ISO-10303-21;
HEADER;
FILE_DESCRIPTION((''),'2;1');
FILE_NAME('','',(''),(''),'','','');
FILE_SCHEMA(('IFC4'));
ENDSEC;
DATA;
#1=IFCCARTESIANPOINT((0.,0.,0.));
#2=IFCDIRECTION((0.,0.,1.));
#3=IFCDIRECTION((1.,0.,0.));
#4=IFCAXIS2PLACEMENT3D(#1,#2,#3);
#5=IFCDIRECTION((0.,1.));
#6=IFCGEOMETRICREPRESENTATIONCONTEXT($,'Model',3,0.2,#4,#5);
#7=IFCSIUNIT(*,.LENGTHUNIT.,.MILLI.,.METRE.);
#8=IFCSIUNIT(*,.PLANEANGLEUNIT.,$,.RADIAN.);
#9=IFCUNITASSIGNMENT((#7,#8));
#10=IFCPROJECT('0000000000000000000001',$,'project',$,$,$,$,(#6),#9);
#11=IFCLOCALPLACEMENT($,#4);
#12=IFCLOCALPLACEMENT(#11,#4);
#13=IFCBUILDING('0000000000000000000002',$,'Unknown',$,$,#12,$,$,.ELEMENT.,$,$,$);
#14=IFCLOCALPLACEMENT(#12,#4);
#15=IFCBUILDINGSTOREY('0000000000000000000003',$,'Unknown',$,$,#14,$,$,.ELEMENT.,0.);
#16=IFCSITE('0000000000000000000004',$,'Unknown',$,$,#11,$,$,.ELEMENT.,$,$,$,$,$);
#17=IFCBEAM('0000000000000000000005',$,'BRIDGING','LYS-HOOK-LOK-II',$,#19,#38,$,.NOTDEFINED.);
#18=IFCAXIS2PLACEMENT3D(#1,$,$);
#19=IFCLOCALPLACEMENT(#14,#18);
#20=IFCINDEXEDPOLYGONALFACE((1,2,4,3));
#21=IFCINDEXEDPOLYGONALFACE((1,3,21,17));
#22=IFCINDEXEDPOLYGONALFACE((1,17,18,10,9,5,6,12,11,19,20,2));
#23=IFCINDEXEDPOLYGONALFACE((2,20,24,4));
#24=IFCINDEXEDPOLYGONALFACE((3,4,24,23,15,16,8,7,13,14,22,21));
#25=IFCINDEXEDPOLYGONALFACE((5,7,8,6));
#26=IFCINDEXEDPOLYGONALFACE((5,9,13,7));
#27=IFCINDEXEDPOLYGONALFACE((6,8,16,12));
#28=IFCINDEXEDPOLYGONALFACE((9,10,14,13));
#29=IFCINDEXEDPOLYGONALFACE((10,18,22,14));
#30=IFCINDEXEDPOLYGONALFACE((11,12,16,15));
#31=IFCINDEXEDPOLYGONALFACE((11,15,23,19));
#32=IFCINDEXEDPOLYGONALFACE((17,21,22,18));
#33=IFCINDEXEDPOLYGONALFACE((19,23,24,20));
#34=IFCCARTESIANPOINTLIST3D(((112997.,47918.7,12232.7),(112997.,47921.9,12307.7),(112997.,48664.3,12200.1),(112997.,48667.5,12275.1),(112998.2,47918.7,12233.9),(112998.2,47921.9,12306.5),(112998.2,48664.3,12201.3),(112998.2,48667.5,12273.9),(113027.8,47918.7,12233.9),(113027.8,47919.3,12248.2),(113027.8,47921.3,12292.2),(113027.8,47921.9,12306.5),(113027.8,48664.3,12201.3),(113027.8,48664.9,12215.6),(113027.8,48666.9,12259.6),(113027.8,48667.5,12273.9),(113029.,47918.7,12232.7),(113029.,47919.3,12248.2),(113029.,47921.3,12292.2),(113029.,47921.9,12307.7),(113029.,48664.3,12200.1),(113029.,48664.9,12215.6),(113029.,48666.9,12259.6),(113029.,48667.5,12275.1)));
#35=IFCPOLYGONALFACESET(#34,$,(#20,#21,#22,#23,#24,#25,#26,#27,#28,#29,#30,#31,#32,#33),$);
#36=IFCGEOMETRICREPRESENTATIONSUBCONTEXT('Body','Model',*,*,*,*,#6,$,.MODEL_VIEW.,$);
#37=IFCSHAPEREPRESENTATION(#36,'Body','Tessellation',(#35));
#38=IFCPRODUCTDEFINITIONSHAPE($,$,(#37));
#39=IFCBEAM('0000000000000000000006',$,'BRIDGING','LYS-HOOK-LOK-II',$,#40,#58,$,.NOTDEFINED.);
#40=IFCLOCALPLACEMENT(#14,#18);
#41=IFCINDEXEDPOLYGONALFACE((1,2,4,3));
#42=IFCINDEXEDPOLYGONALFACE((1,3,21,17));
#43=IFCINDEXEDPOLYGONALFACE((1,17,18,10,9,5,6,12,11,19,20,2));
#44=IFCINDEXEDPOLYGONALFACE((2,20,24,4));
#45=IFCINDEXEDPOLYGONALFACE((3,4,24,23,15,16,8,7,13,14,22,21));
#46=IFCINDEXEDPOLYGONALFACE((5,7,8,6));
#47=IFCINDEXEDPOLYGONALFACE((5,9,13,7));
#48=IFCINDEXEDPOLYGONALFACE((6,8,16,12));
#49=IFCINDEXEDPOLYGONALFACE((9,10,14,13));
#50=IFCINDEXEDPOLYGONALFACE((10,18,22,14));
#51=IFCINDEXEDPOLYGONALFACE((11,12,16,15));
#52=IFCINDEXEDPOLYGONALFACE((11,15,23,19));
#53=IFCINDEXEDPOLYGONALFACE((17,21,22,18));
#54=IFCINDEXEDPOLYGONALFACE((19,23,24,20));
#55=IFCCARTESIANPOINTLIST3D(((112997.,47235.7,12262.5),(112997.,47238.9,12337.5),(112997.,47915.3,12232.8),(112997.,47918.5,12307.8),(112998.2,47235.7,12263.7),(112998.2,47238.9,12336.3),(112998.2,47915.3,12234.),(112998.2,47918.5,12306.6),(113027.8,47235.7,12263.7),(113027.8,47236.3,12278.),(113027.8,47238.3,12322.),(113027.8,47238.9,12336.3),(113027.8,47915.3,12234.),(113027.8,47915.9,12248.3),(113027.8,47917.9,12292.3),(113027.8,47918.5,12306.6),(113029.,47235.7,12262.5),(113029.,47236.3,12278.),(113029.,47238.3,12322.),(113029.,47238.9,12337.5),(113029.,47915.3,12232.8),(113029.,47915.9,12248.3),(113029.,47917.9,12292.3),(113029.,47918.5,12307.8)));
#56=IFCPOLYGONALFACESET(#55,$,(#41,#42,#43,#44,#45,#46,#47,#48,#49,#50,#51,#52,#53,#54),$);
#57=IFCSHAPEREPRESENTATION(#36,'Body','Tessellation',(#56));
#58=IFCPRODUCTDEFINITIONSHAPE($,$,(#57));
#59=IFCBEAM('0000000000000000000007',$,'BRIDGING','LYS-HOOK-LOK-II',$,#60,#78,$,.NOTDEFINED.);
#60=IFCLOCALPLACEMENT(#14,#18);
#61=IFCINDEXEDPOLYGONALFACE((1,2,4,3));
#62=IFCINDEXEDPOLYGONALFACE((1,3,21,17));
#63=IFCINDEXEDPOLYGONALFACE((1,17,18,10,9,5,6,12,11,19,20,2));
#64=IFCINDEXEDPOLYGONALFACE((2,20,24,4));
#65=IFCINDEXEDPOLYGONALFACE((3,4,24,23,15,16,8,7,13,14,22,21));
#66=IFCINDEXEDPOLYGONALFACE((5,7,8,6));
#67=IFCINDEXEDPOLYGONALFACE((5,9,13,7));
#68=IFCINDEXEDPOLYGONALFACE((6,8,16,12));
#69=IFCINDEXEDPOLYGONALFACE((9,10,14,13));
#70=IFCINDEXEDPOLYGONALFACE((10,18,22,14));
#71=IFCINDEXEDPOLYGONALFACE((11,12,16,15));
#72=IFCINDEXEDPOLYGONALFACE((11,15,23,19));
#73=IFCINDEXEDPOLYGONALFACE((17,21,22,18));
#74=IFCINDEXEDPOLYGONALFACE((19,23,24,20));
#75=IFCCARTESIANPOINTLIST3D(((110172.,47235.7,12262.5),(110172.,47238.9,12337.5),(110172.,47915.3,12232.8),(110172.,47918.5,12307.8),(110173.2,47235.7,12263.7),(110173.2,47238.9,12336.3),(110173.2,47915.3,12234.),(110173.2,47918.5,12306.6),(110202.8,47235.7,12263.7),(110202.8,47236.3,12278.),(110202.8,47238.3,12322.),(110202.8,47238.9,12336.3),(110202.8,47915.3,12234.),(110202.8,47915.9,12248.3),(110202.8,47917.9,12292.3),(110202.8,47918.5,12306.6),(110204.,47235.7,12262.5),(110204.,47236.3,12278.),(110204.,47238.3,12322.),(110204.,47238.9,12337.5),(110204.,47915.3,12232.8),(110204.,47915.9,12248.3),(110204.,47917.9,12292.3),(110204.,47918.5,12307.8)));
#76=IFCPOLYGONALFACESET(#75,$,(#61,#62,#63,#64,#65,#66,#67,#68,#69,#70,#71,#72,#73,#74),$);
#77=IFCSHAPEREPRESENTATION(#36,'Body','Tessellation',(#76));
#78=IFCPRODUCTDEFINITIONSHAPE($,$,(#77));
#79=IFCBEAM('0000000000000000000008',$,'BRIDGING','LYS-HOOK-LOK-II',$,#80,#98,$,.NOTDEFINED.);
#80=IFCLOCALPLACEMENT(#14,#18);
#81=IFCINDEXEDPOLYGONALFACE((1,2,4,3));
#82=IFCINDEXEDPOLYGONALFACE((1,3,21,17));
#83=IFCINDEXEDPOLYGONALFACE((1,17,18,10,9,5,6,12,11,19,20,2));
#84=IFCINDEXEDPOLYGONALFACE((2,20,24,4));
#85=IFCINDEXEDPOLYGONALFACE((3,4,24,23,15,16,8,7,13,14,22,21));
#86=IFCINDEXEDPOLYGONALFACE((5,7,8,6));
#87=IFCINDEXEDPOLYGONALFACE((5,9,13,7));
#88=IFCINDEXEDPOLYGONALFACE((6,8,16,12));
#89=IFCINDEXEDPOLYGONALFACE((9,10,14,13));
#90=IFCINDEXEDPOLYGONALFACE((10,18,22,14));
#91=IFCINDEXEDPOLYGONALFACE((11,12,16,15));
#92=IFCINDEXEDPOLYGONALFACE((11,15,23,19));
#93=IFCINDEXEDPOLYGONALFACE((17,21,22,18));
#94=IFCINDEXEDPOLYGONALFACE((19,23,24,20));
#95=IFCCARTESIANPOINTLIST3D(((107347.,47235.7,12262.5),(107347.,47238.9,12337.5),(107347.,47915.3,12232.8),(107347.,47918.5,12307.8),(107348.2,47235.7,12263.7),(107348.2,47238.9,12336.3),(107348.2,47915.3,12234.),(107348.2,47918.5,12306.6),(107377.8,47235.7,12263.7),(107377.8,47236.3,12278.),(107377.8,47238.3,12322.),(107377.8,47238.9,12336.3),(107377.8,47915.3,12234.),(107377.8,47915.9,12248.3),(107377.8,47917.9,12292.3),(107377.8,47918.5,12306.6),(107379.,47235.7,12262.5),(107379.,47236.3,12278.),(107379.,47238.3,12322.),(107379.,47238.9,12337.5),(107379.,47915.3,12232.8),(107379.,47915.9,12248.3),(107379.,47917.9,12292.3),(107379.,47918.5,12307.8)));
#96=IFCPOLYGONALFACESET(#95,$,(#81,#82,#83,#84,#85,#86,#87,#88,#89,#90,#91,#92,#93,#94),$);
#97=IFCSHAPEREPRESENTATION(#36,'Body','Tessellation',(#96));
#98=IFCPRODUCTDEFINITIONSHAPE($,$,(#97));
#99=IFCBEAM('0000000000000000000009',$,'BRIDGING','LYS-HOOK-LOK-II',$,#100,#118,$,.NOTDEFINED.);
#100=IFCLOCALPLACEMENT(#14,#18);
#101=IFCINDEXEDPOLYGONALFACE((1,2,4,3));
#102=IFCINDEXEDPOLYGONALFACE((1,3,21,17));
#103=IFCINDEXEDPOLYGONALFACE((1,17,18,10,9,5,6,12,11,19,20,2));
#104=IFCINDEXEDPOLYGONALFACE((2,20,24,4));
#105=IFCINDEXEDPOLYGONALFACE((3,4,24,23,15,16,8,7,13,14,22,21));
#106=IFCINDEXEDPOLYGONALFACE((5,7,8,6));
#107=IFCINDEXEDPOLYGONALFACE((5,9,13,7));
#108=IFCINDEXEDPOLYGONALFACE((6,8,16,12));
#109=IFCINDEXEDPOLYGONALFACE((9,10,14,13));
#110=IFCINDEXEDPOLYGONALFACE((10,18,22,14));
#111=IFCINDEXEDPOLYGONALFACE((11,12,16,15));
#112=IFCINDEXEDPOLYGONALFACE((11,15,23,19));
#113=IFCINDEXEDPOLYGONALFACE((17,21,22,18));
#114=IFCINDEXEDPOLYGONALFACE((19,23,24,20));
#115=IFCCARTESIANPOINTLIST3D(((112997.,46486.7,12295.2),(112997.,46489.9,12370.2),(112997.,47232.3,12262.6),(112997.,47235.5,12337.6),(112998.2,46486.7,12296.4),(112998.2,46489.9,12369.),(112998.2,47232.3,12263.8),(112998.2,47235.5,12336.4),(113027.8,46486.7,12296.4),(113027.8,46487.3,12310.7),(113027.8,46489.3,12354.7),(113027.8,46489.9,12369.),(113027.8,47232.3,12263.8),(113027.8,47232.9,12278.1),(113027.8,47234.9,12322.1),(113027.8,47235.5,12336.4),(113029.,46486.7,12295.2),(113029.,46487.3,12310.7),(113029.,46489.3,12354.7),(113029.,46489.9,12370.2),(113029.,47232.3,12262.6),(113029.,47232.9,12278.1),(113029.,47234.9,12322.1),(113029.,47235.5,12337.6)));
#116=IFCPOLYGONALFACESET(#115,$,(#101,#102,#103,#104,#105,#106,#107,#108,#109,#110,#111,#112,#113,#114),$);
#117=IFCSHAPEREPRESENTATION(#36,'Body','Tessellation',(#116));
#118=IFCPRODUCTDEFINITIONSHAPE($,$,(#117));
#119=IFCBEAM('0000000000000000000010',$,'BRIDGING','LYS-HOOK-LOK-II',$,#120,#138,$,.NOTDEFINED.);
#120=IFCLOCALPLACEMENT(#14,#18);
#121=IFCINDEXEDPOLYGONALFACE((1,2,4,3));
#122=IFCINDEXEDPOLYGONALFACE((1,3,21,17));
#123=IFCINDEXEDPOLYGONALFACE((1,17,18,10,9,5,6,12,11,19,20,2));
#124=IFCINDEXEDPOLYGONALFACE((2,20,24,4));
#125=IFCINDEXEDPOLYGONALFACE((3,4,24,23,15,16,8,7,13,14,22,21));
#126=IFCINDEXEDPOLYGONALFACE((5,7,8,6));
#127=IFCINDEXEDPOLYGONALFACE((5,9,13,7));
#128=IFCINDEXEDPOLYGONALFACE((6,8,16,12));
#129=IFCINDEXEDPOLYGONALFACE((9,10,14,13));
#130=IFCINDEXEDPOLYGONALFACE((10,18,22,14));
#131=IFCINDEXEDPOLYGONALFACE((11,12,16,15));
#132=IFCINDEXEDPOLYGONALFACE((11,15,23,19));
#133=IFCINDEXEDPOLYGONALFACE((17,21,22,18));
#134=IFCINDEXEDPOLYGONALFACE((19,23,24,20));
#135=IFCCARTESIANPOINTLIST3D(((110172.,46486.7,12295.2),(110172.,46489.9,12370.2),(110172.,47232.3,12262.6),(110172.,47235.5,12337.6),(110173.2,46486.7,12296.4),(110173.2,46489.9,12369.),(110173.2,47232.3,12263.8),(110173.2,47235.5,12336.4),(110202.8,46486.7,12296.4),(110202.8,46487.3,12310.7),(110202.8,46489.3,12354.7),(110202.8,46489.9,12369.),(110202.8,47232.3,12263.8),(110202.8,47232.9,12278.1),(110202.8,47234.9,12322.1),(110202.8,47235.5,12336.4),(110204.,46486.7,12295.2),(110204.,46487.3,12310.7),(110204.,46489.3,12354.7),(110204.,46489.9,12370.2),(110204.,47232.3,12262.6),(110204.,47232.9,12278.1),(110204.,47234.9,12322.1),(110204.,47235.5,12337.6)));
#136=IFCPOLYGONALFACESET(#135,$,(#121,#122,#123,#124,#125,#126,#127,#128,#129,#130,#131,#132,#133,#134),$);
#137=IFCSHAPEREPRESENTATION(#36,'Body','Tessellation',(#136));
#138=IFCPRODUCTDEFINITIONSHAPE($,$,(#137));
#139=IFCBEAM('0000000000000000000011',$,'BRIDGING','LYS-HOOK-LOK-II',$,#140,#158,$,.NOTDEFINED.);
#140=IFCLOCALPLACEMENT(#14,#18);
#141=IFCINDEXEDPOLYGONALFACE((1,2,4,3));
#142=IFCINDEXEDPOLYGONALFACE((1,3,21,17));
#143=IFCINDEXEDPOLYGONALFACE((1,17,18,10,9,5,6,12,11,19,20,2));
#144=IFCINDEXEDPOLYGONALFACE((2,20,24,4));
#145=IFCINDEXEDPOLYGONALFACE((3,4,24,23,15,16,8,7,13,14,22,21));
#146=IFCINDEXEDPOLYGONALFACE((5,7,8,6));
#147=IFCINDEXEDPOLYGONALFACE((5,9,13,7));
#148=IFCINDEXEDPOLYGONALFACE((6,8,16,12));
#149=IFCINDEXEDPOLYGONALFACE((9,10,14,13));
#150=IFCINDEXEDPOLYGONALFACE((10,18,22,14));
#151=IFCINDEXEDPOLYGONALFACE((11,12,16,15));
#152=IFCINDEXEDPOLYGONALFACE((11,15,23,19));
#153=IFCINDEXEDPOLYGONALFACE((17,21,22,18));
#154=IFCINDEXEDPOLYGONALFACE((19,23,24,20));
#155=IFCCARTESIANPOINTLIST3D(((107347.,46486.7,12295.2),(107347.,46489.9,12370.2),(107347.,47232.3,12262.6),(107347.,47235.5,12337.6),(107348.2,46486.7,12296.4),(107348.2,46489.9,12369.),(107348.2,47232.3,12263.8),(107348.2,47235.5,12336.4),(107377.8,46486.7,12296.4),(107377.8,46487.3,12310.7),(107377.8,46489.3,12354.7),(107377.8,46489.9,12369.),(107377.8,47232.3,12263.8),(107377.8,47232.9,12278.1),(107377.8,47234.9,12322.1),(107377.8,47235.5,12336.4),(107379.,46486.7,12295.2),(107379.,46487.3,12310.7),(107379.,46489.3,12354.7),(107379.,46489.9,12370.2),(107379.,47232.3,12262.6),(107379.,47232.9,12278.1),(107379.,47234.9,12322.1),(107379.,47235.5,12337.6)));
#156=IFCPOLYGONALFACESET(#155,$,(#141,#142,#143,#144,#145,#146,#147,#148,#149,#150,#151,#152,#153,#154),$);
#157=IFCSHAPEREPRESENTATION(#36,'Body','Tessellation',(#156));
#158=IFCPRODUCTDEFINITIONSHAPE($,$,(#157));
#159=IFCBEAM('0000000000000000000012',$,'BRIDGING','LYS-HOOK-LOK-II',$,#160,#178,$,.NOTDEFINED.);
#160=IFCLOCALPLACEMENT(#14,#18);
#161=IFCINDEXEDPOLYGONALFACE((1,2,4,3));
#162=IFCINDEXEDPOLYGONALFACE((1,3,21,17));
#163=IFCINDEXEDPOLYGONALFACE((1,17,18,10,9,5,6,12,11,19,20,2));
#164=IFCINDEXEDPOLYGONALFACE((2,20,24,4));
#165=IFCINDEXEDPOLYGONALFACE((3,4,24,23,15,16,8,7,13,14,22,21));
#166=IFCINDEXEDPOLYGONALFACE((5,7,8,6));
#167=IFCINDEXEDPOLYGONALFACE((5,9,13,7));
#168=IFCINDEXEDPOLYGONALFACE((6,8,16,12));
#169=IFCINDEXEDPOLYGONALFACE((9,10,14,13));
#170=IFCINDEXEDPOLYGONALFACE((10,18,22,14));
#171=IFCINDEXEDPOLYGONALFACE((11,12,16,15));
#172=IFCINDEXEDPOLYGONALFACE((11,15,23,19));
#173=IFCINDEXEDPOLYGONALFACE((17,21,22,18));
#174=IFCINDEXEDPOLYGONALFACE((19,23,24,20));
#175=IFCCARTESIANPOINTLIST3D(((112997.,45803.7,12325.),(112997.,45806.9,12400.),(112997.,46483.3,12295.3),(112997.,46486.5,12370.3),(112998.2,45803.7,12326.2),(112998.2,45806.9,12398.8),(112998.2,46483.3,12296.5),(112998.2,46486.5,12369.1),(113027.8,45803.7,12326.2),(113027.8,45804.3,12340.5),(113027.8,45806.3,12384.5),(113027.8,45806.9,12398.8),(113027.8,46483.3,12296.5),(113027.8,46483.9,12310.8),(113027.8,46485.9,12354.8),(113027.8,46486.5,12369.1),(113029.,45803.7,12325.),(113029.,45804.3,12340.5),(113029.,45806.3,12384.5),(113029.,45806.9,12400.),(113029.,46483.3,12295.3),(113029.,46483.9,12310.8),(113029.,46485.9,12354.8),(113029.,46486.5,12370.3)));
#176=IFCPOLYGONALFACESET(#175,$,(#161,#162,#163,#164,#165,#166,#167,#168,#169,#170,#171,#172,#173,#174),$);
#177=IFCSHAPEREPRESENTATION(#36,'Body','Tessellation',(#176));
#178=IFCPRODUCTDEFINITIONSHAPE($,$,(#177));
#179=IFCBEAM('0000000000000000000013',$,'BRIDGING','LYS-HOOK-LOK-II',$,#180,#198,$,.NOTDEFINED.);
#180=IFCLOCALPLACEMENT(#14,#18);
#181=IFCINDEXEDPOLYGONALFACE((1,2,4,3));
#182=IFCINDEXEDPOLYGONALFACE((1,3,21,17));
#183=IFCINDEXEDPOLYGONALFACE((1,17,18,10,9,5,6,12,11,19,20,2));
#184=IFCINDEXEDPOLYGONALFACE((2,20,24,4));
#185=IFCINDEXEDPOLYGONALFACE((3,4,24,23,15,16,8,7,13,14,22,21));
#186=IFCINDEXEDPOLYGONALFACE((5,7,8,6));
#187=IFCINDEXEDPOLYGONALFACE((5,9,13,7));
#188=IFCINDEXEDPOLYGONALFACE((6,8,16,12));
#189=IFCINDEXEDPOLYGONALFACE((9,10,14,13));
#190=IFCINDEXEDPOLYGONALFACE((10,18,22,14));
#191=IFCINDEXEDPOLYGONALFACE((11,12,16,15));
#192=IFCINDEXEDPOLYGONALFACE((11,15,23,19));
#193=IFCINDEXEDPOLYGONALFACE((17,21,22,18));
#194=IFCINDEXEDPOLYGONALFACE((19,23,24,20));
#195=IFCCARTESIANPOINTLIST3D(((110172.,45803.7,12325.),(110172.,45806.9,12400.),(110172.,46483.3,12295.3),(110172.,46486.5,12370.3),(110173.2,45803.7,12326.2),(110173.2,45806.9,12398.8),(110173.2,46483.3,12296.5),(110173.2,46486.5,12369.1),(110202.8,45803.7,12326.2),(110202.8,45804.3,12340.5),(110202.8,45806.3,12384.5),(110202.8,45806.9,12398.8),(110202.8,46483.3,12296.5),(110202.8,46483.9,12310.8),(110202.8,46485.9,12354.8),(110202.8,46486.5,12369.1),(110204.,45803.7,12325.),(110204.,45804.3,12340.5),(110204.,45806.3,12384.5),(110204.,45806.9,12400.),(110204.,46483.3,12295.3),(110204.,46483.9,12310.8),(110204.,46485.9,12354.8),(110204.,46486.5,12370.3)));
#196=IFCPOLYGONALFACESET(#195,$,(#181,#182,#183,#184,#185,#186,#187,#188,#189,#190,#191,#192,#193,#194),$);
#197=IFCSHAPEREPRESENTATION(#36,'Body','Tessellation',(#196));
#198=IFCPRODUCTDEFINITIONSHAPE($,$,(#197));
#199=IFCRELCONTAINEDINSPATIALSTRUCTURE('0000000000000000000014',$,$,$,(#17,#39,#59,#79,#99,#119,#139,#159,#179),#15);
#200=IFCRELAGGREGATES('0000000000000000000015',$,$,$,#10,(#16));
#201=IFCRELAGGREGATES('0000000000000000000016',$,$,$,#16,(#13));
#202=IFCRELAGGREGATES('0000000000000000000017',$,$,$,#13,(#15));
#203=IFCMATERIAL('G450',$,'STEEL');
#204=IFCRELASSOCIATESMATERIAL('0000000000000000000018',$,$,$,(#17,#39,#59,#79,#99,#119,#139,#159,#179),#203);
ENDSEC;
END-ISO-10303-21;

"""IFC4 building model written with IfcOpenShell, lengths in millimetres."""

from ifc_helpers import new_model, si_unit, direction, frame, origin_with_axes, place, context, subcontext, project, spatial, line, indexed_curve, outline, extrude, material, element, save


model = new_model("IFC4")

# Units and contexts
model_context = context("Model", 3, precision=0.2, world=origin_with_axes(), true_north=direction((0.0, 1.0)))
body_context = subcontext(model_context, "Body", "Model", "MODEL_VIEW")
ifc_project = project(units=[si_unit("LENGTHUNIT", "METRE", prefix="MILLI"), si_unit("PLANEANGLEUNIT", "RADIAN")], contexts=[model_context])

# Site, building, storey
site_placement = place(None, origin_with_axes())
site = spatial("IfcSite", under=ifc_project, at=site_placement, Name="Unknown", CompositionType="ELEMENT")
building_placement = place(site_placement, origin_with_axes())
building = spatial("IfcBuilding", under=site, at=building_placement, Name="Unknown", CompositionType="ELEMENT")
storey_placement = place(building_placement, origin_with_axes())
storey = spatial("IfcBuildingStorey", under=building, at=storey_placement, Name="Unknown", CompositionType="ELEMENT", Elevation=0.0)

# Beams
ifc_material_1 = material(Name="G450", Category="STEEL")
beam_1_placement = place(storey_placement, frame((113013.0, 47920.3, 12270.2), z_axis=(1.0, 0.0, 0.0), x_axis=(0.0, 0.999046, -0.043681)))
element("IfcBeam", 1, at=beam_1_placement, inside=storey, material=ifc_material_1, Name="BRIDGING", Description="LYS-HOOK-LOK-II", PredefinedType="NOTDEFINED", context=body_context, shape_type="SolidModel", body=[
    extrude(outline(indexed_curve([(16.0, -37.5), (16.0, -22.0), (14.8, -22.0), (14.8, -36.3), (-14.8, -36.3), (-14.8, 36.3), (14.8, 36.3), (14.8, 22.0), (16.0, 22.0), (16.0, 37.5), (-16.0, 37.5), (-16.0, -37.5)], segments=[line(1, 2, 3, 4, 5, 6, 7, 8, 9, 10, 11, 12, 1)])), frame((0.0, 0.0, 0.0), z_axis=(-1.0, 0.0, 0.0), x_axis=(0.0, 0.0, 1.0)), (0.0, 0.0, -1.0), 746.3),
])
for number, where, z_axis, x_axis, name in (
    (2, (113013.0, 47237.3, 12300.0), (1.0, 0.0, 0.0), (0.0, 0.999046, -0.043661), "BRIDGING"),
    (3, (110188.0, 47237.3, 12300.0), (1.0, 0.0, 0.0), (0.0, 0.999046, -0.043661), "BRIDGING"),
    (4, (107363.0, 47237.3, 12300.0), (1.0, 0.0, 0.0), (0.0, 0.999046, -0.043661), "BRIDGING"),
):
    element("IfcBeam", number, at=place(storey_placement, frame(where, z_axis=z_axis, x_axis=x_axis)), inside=storey, material=ifc_material_1, Name=name, Description="LYS-HOOK-LOK-II", PredefinedType="NOTDEFINED", context=body_context, shape_type="SolidModel", body=[
        extrude(outline(indexed_curve([(16.0, -37.5), (16.0, -22.0), (14.8, -22.0), (14.8, -36.3), (-14.8, -36.3), (-14.8, 36.3), (14.8, 36.3), (14.8, 22.0), (16.0, 22.0), (16.0, 37.5), (-16.0, 37.5), (-16.0, -37.5)], segments=[line(1, 2, 3, 4, 5, 6, 7, 8, 9, 10, 11, 12, 1)])), frame((0.0, 0.0, 0.0), z_axis=(-1.0, 0.0, 0.0), x_axis=(0.0, 0.0, 1.0)), (0.0, 0.0, -1.0), 680.2),
    ])
for number, where, z_axis, x_axis, name in (
    (5, (113013.0, 46488.3, 12332.7), (1.0, 0.0, 0.0), (0.0, 0.999046, -0.043681), "BRIDGING"),
    (6, (110188.0, 46488.3, 12332.7), (1.0, 0.0, 0.0), (0.0, 0.999046, -0.043681), "BRIDGING"),
    (7, (107363.0, 46488.3, 12332.7), (1.0, 0.0, 0.0), (0.0, 0.999046, -0.043681), "BRIDGING"),
):
    element("IfcBeam", number, at=place(storey_placement, frame(where, z_axis=z_axis, x_axis=x_axis)), inside=storey, material=ifc_material_1, Name=name, Description="LYS-HOOK-LOK-II", PredefinedType="NOTDEFINED", context=body_context, shape_type="SolidModel", body=[
        extrude(outline(indexed_curve([(16.0, -37.5), (16.0, -22.0), (14.8, -22.0), (14.8, -36.3), (-14.8, -36.3), (-14.8, 36.3), (14.8, 36.3), (14.8, 22.0), (16.0, 22.0), (16.0, 37.5), (-16.0, 37.5), (-16.0, -37.5)], segments=[line(1, 2, 3, 4, 5, 6, 7, 8, 9, 10, 11, 12, 1)])), frame((0.0, 0.0, 0.0), z_axis=(-1.0, 0.0, 0.0), x_axis=(0.0, 0.0, 1.0)), (0.0, 0.0, -1.0), 746.3),
    ])
for number, where, z_axis, x_axis, name in (
    (8, (113013.0, 45805.3, 12362.5), (1.0, 0.0, 0.0), (0.0, 0.999046, -0.043661), "BRIDGING"),
    (9, (110188.0, 45805.3, 12362.5), (1.0, 0.0, 0.0), (0.0, 0.999046, -0.043661), "BRIDGING"),
):
    element("IfcBeam", number, at=place(storey_placement, frame(where, z_axis=z_axis, x_axis=x_axis)), inside=storey, material=ifc_material_1, Name=name, Description="LYS-HOOK-LOK-II", PredefinedType="NOTDEFINED", context=body_context, shape_type="SolidModel", body=[
        extrude(outline(indexed_curve([(16.0, -37.5), (16.0, -22.0), (14.8, -22.0), (14.8, -36.3), (-14.8, -36.3), (-14.8, 36.3), (14.8, 36.3), (14.8, 22.0), (16.0, 22.0), (16.0, 37.5), (-16.0, 37.5), (-16.0, -37.5)], segments=[line(1, 2, 3, 4, 5, 6, 7, 8, 9, 10, 11, 12, 1)])), frame((0.0, 0.0, 0.0), z_axis=(-1.0, 0.0, 0.0), x_axis=(0.0, 0.0, 1.0)), (0.0, 0.0, -1.0), 680.2),
    ])

save(model, "model.ifc")
